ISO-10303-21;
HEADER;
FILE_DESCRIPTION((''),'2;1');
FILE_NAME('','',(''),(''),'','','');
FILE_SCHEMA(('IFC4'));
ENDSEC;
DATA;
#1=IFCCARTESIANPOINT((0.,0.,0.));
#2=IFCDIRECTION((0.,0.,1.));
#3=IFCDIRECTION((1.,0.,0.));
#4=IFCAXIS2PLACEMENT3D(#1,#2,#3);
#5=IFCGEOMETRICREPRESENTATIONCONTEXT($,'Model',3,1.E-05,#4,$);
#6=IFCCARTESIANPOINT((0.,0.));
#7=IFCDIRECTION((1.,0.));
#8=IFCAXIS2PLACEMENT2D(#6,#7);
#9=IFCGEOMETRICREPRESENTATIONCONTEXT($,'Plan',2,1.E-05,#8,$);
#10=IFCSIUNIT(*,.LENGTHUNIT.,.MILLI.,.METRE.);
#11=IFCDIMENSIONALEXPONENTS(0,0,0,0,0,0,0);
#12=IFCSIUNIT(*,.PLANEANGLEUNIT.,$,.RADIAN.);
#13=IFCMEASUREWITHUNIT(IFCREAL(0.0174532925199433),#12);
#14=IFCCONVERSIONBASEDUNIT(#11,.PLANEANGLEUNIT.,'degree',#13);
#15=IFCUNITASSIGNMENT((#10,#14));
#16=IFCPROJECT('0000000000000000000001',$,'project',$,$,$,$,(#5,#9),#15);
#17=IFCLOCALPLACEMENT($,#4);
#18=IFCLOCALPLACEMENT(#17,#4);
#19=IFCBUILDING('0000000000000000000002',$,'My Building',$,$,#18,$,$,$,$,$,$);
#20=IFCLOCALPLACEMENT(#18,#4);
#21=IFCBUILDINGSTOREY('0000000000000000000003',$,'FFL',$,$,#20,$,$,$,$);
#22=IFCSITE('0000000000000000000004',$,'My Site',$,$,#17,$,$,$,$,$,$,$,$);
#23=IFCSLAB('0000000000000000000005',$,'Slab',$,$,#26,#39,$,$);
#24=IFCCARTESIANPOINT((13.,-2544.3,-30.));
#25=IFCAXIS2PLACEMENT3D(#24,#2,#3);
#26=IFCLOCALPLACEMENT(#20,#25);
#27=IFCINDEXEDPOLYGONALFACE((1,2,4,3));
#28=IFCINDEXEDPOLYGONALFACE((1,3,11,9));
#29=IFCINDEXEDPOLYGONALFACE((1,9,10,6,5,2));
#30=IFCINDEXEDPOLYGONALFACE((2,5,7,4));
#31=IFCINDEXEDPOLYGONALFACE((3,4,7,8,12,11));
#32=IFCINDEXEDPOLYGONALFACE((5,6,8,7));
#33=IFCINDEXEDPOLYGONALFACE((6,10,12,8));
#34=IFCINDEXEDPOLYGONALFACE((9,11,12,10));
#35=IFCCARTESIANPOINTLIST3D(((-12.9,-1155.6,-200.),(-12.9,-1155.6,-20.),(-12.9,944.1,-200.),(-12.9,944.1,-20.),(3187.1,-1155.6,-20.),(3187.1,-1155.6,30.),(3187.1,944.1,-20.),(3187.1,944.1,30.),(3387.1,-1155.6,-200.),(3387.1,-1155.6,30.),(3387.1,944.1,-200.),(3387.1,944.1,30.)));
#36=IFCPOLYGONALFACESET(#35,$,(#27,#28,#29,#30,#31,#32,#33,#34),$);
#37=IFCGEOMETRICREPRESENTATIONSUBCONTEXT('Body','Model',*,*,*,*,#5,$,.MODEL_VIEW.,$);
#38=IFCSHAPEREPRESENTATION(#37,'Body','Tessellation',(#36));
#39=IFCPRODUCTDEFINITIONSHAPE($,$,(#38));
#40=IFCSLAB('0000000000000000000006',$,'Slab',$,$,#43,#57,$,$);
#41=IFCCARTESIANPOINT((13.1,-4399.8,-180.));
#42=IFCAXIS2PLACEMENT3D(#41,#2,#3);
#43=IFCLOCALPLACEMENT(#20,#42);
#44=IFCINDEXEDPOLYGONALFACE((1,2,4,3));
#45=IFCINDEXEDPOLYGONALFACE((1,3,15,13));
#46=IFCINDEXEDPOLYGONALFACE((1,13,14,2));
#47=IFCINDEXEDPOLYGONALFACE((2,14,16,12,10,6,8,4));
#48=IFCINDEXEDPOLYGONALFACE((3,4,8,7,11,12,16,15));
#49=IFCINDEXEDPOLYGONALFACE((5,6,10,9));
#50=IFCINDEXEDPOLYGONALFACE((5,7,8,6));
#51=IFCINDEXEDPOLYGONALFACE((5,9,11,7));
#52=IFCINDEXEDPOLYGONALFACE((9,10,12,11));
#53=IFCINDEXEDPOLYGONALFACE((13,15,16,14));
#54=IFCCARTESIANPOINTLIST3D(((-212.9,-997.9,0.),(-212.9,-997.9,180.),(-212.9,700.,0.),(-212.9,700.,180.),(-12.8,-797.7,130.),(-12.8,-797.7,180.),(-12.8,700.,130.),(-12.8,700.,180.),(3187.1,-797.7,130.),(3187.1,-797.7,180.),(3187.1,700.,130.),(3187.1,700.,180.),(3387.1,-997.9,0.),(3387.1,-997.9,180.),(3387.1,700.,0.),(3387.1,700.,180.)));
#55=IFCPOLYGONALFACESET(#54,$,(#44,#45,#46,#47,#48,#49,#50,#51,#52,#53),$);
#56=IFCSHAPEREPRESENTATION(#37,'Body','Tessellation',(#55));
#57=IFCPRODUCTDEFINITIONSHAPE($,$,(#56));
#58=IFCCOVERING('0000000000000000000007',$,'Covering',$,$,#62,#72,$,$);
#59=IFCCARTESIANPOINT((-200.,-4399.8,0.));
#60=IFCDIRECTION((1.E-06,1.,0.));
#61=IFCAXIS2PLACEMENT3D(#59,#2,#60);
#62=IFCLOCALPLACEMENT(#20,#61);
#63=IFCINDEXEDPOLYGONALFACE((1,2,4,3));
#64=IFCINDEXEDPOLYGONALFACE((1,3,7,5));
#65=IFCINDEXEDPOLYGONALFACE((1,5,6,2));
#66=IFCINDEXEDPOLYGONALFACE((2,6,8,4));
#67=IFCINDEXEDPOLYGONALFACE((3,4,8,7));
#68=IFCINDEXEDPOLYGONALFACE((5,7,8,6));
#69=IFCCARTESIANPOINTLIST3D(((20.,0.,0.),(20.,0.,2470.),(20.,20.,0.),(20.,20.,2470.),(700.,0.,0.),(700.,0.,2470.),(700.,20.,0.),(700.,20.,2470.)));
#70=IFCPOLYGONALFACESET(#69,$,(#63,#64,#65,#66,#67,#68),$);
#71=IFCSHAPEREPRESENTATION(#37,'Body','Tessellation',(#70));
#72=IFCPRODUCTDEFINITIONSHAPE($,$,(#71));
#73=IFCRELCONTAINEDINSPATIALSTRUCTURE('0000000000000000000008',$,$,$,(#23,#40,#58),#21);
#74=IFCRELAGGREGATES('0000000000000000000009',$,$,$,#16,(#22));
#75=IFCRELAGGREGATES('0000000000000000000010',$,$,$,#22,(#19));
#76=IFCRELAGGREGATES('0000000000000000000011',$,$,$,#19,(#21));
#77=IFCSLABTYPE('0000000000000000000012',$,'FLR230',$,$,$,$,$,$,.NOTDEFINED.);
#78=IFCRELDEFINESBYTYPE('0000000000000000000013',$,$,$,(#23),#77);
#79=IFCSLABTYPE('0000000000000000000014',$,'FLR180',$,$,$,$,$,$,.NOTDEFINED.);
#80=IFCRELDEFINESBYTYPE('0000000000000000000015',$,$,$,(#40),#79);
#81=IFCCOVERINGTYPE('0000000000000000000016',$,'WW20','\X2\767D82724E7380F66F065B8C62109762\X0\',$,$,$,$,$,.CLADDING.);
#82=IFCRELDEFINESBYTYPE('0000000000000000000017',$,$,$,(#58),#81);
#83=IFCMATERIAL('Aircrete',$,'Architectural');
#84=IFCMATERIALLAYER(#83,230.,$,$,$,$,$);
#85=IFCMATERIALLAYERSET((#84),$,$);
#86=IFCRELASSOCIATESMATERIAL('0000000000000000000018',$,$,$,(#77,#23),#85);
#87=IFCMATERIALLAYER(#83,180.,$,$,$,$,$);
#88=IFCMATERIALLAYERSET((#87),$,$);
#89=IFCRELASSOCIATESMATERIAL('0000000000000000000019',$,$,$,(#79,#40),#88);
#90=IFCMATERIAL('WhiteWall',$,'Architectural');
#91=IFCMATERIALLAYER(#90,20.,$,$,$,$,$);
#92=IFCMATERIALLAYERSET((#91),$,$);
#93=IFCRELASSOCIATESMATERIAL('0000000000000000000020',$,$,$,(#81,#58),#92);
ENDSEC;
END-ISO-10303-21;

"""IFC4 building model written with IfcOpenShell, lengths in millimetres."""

from ifc_helpers import new_model, entity, si_unit, converted_unit, frame, origin_with_axes, origin_2d_with_axis, place, context, subcontext, project, spatial, line, indexed_curve, outline, extrude, material, layer, layer_set, layer_usage, type_object, element, save


model = new_model("IFC4")

# Units and contexts
model_context = context("Model", 3, precision=1e-05, world=origin_with_axes())
plan_context = context("Plan", 2, precision=1e-05, world=origin_2d_with_axis())
body_context_1 = subcontext(model_context, "Body", "Model", "MODEL_VIEW")
ifc_project = project(units=[si_unit("LENGTHUNIT", "METRE", prefix="MILLI"), converted_unit("PLANEANGLEUNIT", "degree", entity("IfcReal", 0.0174532925199433), si_unit("PLANEANGLEUNIT", "RADIAN"), dimensions=[0, 0, 0, 0, 0, 0, 0])], contexts=[model_context, plan_context])

# Site, building, storey
site_placement = place(None, origin_with_axes())
site = spatial("IfcSite", under=ifc_project, at=site_placement, Name="My Site")
building_placement = place(site_placement, origin_with_axes())
building = spatial("IfcBuilding", under=site, at=building_placement, Name="My Building")
storey_placement = place(building_placement, origin_with_axes())
storey = spatial("IfcBuildingStorey", under=building, at=storey_placement, Name="FFL")

# Shared definitions
ifc_material_1 = material(Name="Aircrete", Category="Architectural")
ifc_layer_1 = layer(ifc_material_1, 230.0)
ifc_layer_set_1 = layer_set([ifc_layer_1])
slab_type_1 = type_object("IfcSlabType", Name="FLR230", PredefinedType="NOTDEFINED", material=ifc_layer_set_1)

# Slabs, openings
ifc_layer_usage_1 = layer_usage(ifc_layer_set_1, "AXIS3", "POSITIVE", -200.0)
slab_1_placement = place(storey_placement, frame((13.0, -2544.3, -30.0), z_axis=(0.0, 0.0, 1.0), x_axis=(1.0, 0.0, 0.0)))
slab_1 = element("IfcSlab", 1, at=slab_1_placement, inside=storey, type_object=slab_type_1, material=ifc_layer_usage_1, Name="Slab", context=body_context_1, shape_type="SweptSolid", body=[
    extrude(outline(indexed_curve([(-12.9, -1155.6), (3387.1, -1155.6), (3387.1, 944.1), (-12.9, 944.1), (-12.9, -1155.6)])), frame((0.0, 0.0, -200.0), z_axis=(0.0, 0.0, 1.0), x_axis=(1.0, 0.0, 0.0)), (0.0, 0.0, 1.0), 230.0),
])
opening_1_placement = place(slab_1_placement, frame((0.0, 0.0, 30.0), z_axis=(0.0, 0.0, 1.0), x_axis=(1.0, 0.0, 0.0)))
element("IfcOpeningElement", 2, at=opening_1_placement, cuts=slab_1, PredefinedType="OPENING", context=body_context_1, shape_type="SweptSolid", body=[
    extrude(outline(indexed_curve([(-13.5, 944.1), (3187.1, 944.1), (3187.1, -1155.6), (-13.5, -1155.6), (-13.5, 944.1)])), frame((0.0, 0.0, -50.0), z_axis=(0.0, 0.0, 1.0), x_axis=(1.0, 0.0, 0.0)), (0.0, 0.0, 1.0), 100.0),
])
ifc_layer_2 = layer(ifc_material_1, 180.0)
ifc_layer_set_2 = layer_set([ifc_layer_2])
ifc_layer_usage_2 = layer_usage(ifc_layer_set_2, "AXIS3", "POSITIVE", 0.0)
slab_type_2 = type_object("IfcSlabType", Name="FLR180", PredefinedType="NOTDEFINED", material=ifc_layer_set_2)
slab_2_placement = place(storey_placement, frame((13.1, -4399.8, -180.0), z_axis=(0.0, 0.0, 1.0), x_axis=(1.0, 0.0, 0.0)))
slab_2 = element("IfcSlab", 3, at=slab_2_placement, inside=storey, type_object=slab_type_2, material=ifc_layer_usage_2, Name="Slab", context=body_context_1, shape_type="SweptSolid", body=[
    extrude(outline(indexed_curve([(-212.9, -997.9), (3387.1, -997.9), (3387.1, 700.0), (-212.9, 700.0), (-212.9, -997.9)])), None, (0.0, 0.0, 1.0), 180.0),
])
opening_2_placement = place(slab_2_placement, frame((-12.8, 706.5, 130.0), z_axis=(0.0, 0.0, 1.0), x_axis=(0.0, -1.0, 0.0)))
element("IfcOpeningElement", 4, at=opening_2_placement, cuts=slab_2, PredefinedType="OPENING", context=body_context_1, shape_type="SweptSolid", body=[
    extrude(outline(indexed_curve([(0.0, 0.0), (1504.2, 0.0), (1504.2, 3200.0), (0.0, 3200.0), (0.0, 0.0)])), origin_with_axes(), (0.0, 0.0, 1.0), 100.0),
])

# Covering
ifc_material_2 = material(Name="WhiteWall", Category="Architectural")
ifc_layer_3 = layer(ifc_material_2, 20.0)
ifc_layer_set_3 = layer_set([ifc_layer_3])
ifc_layer_usage_3 = layer_usage(ifc_layer_set_3, "AXIS2", "POSITIVE", 0.0)
covering_type = type_object("IfcCoveringType", Name="WW20", Description="白色乳胶漆完成面", PredefinedType="CLADDING", material=ifc_layer_set_3)
covering_1_placement = place(storey_placement, frame((-200.0, -4399.8, 0.0), z_axis=(0.0, 0.0, 1.0), x_axis=(0.000001, 1.0, 0.0)))
element("IfcCovering", 5, at=covering_1_placement, inside=storey, type_object=covering_type, material=ifc_layer_usage_3, Name="Covering", context=body_context_1, shape_type="SweptSolid", body=[
    extrude(outline(indexed_curve([(20.0, 0.0), (20.0, 20.0), (700.0, 20.0), (700.0, 0.0)], segments=[line(1, 2, 3, 4, 1)])), origin_with_axes(), (0.0, 0.0, 1.0), 2470.0),
])

save(model, "model.ifc")
